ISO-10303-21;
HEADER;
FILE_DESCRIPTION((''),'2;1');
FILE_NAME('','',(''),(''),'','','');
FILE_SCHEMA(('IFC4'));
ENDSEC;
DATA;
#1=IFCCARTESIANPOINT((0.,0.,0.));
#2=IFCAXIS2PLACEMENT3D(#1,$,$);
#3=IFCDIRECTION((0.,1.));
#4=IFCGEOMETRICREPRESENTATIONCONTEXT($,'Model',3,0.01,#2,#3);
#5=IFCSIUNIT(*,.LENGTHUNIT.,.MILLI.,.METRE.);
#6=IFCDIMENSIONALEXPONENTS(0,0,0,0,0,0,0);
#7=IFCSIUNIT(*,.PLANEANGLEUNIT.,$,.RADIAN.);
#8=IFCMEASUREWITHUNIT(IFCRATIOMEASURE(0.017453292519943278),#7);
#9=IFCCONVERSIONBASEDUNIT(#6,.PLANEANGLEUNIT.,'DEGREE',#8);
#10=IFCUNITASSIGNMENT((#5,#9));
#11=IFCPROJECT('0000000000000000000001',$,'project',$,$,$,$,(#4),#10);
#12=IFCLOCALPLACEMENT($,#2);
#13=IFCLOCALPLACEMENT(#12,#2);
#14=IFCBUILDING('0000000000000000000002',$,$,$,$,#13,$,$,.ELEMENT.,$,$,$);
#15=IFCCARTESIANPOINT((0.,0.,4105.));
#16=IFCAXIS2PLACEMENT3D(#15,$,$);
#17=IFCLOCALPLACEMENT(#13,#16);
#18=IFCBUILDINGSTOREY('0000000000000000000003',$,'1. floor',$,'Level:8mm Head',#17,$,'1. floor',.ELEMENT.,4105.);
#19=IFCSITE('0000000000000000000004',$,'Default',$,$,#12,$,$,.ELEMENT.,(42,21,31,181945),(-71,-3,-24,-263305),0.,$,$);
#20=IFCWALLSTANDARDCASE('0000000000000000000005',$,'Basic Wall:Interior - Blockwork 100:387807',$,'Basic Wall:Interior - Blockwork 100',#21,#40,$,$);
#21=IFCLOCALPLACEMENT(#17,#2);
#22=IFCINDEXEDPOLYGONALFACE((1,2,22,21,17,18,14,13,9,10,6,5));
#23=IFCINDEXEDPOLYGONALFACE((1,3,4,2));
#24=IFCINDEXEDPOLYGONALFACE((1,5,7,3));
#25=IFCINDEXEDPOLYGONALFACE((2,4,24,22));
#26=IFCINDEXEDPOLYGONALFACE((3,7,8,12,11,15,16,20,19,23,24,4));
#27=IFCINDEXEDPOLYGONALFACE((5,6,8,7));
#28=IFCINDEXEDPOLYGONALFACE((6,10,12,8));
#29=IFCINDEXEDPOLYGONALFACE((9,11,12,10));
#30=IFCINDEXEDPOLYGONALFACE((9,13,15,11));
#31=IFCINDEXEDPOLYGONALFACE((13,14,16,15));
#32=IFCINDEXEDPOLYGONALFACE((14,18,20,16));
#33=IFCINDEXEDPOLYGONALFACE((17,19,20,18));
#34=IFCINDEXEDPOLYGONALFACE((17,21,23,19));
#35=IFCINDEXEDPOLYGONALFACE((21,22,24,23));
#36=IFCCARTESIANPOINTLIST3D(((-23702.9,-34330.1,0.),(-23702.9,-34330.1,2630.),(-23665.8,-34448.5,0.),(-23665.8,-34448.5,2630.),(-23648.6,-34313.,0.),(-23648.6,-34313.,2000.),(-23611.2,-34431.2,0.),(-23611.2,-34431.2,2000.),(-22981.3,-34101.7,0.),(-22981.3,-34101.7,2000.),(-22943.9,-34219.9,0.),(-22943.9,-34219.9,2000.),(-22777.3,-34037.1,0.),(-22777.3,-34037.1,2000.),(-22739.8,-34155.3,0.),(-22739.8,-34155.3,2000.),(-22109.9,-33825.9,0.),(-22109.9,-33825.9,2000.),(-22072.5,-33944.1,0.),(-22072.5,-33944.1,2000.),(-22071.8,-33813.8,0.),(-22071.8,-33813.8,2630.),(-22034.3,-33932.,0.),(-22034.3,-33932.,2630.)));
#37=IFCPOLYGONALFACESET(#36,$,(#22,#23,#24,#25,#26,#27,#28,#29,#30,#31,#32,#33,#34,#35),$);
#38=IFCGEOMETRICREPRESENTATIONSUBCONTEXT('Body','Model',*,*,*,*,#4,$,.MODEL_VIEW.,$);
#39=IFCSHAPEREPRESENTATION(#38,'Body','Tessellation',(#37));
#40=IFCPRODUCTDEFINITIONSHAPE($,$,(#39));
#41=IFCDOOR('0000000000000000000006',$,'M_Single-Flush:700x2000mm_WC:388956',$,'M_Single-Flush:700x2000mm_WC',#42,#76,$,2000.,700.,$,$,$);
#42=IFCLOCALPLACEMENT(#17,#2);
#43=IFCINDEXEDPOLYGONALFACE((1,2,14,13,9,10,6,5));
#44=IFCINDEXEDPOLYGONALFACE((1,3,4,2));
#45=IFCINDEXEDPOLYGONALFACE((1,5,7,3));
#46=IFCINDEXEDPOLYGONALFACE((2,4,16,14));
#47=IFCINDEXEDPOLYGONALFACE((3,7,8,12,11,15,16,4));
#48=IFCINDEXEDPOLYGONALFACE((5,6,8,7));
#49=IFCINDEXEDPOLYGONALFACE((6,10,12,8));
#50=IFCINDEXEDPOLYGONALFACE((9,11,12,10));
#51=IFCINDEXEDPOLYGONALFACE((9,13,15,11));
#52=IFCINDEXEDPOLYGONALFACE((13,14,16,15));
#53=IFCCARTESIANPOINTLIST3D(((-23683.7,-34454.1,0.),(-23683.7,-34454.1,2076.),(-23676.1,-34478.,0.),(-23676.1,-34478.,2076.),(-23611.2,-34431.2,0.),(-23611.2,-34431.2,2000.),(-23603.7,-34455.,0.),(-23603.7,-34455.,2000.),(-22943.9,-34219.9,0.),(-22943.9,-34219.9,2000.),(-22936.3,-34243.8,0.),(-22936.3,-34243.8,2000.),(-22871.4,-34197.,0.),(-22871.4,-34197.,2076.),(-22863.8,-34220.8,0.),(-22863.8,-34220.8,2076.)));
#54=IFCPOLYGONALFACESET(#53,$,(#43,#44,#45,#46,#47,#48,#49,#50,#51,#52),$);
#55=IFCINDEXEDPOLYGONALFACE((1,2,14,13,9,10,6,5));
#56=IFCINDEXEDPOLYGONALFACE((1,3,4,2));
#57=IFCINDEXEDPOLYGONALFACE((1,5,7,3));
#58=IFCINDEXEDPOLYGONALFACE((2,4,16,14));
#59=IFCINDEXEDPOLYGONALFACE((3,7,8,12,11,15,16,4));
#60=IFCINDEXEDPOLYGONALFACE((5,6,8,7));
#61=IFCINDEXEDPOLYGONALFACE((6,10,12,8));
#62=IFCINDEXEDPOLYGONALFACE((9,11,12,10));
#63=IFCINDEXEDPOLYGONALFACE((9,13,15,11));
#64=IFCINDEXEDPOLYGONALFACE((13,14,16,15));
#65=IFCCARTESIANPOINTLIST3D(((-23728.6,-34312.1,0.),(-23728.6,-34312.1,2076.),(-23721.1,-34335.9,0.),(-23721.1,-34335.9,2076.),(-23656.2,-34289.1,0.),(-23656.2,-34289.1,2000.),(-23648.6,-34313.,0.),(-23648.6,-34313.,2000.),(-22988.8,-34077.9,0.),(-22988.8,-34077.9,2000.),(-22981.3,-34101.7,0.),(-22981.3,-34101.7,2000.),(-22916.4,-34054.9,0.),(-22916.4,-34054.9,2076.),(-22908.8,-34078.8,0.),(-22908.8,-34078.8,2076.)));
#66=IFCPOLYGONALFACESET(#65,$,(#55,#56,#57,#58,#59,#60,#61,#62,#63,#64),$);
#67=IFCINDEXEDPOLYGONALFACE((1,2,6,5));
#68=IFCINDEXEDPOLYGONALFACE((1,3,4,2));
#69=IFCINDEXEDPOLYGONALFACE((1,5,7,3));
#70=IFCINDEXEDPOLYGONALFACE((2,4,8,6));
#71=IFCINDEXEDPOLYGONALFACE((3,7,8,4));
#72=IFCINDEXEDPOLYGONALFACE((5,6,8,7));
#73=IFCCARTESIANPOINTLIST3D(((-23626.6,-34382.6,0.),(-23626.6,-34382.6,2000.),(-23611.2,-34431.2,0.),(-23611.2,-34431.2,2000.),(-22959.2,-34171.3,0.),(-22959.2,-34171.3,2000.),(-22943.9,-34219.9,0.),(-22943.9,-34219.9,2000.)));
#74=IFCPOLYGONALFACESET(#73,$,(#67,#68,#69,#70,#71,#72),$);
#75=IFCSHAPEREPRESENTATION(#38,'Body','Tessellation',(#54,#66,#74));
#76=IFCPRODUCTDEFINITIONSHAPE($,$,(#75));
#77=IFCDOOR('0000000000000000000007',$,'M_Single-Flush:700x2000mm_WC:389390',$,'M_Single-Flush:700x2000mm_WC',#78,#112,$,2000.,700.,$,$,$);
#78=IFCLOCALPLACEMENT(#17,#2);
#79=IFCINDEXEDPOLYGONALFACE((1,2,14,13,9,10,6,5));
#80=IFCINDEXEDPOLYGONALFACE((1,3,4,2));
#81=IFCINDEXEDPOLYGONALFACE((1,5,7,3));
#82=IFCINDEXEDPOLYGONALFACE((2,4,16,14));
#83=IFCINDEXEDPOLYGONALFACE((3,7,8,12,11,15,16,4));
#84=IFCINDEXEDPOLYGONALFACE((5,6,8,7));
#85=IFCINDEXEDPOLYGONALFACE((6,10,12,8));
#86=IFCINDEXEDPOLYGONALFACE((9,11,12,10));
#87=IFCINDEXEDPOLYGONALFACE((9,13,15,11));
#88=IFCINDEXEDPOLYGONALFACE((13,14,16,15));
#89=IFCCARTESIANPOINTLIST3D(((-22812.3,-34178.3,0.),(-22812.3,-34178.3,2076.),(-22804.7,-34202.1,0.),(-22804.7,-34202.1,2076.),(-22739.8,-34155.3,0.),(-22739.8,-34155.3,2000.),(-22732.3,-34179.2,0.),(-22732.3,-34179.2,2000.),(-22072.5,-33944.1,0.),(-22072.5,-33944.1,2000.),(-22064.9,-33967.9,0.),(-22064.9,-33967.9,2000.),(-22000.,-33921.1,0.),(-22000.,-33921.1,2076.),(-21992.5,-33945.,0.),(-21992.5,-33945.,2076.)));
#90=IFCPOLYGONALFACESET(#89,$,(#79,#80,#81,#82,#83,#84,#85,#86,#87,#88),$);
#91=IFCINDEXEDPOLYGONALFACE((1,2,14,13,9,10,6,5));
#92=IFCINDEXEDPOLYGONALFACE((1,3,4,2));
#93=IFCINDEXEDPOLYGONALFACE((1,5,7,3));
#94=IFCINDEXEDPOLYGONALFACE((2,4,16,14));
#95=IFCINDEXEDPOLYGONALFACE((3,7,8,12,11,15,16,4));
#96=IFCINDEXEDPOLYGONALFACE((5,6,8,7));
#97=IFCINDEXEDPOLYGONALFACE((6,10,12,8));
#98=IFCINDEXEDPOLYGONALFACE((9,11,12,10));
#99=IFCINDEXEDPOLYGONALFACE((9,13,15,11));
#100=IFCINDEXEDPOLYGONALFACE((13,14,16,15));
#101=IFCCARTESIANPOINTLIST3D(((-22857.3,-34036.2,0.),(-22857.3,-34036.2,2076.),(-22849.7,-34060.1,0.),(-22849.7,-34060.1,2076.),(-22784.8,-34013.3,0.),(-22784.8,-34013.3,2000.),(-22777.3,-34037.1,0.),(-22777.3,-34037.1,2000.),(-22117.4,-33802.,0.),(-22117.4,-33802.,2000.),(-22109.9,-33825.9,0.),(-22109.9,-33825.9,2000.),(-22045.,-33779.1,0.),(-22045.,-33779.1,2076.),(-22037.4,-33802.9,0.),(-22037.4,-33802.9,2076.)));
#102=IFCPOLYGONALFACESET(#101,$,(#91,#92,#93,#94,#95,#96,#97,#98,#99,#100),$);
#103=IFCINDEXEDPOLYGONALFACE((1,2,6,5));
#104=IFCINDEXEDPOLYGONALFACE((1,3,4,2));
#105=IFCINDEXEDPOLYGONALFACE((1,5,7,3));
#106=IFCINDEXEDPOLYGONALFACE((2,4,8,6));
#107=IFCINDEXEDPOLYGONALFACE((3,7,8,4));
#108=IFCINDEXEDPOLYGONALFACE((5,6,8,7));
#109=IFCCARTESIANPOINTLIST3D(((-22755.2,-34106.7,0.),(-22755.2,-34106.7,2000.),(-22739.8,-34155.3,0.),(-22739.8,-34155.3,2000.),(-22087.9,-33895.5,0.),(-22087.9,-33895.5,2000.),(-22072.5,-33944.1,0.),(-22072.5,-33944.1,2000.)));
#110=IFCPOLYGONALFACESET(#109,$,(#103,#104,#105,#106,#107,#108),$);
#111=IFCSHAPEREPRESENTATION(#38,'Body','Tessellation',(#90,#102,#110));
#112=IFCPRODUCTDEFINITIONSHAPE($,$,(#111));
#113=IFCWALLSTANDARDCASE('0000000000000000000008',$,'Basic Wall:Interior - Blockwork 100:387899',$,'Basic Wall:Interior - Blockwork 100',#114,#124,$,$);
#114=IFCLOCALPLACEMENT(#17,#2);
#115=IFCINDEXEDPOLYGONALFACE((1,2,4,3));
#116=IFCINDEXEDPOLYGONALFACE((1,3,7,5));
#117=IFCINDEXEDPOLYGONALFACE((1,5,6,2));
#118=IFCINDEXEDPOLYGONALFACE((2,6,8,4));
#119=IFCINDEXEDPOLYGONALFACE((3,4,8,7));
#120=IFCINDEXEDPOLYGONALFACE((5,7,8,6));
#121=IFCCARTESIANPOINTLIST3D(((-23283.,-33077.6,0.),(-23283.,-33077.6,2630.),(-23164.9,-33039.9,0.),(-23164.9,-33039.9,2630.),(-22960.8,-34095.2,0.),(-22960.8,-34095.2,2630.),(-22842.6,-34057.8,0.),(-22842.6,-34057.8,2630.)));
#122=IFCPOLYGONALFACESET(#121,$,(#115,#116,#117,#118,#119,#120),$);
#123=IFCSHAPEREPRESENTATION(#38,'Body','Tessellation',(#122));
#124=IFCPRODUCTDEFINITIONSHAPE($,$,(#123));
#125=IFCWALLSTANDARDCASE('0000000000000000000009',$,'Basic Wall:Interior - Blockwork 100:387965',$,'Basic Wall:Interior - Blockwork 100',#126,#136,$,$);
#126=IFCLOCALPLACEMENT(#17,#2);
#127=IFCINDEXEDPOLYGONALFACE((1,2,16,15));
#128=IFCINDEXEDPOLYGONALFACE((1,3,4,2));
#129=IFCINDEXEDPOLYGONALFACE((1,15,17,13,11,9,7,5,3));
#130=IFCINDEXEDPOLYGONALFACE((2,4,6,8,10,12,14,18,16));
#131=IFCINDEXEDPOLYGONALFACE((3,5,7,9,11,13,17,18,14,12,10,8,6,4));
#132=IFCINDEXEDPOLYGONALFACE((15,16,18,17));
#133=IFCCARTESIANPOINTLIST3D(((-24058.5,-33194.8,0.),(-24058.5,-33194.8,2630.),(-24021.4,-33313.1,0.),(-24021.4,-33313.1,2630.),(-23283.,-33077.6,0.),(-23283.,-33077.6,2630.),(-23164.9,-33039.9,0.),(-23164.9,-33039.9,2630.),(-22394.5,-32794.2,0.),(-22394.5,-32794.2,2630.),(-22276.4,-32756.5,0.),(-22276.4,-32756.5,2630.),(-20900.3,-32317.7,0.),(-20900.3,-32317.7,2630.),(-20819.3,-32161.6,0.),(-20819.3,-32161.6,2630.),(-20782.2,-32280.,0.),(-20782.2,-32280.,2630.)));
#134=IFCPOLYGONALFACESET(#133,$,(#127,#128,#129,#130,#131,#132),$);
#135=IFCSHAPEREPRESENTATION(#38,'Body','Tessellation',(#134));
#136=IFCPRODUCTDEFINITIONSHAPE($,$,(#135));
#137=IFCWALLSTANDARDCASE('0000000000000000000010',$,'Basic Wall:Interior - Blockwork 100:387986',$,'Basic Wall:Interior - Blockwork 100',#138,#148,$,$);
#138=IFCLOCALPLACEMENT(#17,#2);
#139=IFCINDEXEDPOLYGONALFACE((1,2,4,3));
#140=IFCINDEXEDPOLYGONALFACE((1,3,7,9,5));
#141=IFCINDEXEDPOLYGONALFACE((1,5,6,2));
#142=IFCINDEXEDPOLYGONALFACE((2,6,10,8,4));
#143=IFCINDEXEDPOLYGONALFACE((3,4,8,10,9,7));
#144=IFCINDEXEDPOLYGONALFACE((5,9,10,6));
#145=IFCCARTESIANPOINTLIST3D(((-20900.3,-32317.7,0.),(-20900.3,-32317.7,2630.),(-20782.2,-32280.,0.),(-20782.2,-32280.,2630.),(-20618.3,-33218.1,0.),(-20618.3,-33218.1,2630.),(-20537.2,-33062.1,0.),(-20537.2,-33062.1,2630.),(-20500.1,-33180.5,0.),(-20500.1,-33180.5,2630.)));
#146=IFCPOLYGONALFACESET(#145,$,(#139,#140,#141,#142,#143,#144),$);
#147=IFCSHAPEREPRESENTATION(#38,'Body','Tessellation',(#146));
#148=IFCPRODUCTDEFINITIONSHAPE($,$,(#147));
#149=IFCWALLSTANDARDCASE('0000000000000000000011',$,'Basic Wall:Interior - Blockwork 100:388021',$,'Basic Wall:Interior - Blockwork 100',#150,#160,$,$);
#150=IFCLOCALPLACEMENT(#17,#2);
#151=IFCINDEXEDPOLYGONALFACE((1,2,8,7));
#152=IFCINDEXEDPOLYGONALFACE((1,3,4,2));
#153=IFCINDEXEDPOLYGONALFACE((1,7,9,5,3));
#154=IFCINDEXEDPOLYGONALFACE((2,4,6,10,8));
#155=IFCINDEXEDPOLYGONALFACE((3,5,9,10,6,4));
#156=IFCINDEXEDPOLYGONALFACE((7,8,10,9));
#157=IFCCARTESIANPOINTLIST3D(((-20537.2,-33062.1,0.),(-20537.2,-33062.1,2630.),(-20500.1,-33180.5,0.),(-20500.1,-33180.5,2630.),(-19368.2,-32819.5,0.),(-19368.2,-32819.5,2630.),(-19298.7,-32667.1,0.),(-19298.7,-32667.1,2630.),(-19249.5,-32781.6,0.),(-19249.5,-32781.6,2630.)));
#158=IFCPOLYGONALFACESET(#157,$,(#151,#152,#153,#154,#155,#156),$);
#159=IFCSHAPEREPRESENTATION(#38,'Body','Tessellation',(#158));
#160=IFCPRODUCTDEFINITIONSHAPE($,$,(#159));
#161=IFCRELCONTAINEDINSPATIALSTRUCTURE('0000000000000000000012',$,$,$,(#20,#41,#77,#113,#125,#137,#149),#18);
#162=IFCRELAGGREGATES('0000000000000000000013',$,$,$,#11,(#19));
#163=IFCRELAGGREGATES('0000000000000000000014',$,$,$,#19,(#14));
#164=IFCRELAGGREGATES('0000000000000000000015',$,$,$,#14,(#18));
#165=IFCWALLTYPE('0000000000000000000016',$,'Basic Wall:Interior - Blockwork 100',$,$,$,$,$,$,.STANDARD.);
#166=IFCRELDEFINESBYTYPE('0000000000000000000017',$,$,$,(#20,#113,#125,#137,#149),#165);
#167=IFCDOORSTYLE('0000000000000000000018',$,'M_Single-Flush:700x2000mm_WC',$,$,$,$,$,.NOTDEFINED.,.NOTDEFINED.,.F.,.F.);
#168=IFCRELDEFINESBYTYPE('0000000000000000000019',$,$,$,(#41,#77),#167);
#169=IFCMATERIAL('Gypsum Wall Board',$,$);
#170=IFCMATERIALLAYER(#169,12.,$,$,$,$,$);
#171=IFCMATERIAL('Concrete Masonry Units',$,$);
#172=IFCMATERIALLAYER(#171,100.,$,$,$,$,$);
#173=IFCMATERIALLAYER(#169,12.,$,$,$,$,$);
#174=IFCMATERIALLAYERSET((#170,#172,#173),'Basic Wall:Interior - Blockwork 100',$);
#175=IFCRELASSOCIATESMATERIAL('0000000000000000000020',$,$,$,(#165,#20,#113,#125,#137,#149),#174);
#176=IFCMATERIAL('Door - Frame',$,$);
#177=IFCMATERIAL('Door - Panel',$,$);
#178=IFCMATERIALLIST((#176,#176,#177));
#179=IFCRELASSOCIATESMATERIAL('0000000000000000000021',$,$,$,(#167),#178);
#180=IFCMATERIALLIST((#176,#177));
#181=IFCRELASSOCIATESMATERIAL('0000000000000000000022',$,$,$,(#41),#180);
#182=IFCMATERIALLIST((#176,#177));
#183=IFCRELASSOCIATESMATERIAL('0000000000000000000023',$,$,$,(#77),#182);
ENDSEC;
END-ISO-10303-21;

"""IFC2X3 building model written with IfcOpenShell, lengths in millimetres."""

from ifc_helpers import new_model, entity, si_unit, converted_unit, direction, frame, frame_2d, origin, origin_2d_with_axis, place, context, subcontext, project, spatial, polyline, rectangle, outline, extrude, source, transform, mapped, material, material_list, layer, layer_set, layer_usage, type_object, type_shapes, element, fill, save


model = new_model("IFC2X3")

# Units and contexts
model_context = context("Model", 3, precision=0.01, world=origin(), true_north=direction((0.0, 1.0)))
body_context = subcontext(model_context, "Body", "Model", "MODEL_VIEW")
ifc_project = project(units=[si_unit("LENGTHUNIT", "METRE", prefix="MILLI"), converted_unit("PLANEANGLEUNIT", "DEGREE", entity("IfcRatioMeasure", 0.017453292519943278), si_unit("PLANEANGLEUNIT", "RADIAN"), dimensions=[0, 0, 0, 0, 0, 0, 0])], contexts=[model_context])

# Site, building, storey
site_placement = place(None, origin())
site = spatial("IfcSite", under=ifc_project, at=site_placement, Name="Default", CompositionType="ELEMENT", RefLatitude=(42, 21, 31, 181945), RefLongitude=(-71, -3, -24, -263305), RefElevation=0.0)
building_placement = place(site_placement, origin())
building = spatial("IfcBuilding", under=site, at=building_placement, CompositionType="ELEMENT")
storey_placement = place(building_placement, frame((0.0, 0.0, 4105.0)))
storey = spatial("IfcBuildingStorey", under=building, at=storey_placement, Name="1. floor", ObjectType="Level:8mm Head", LongName="1. floor", CompositionType="ELEMENT", Elevation=4105.0)

# Shared definitions
ifc_material_1 = material(Name="Gypsum Wall Board")
ifc_layer_1 = layer(ifc_material_1, 12.0)
ifc_material_2 = material(Name="Concrete Masonry Units")
ifc_layer_2 = layer(ifc_material_2, 100.0)
ifc_layer_3 = layer(ifc_material_1, 12.0)
ifc_layer_set = layer_set([ifc_layer_1, ifc_layer_2, ifc_layer_3], Name="Basic Wall:Interior - Blockwork 100")
wall_type = type_object("IfcWallType", Name="Basic Wall:Interior - Blockwork 100", PredefinedType="STANDARD", material=ifc_layer_set)
ifc_material_3 = material(Name="Door - Frame")
ifc_material_4 = material(Name="Door - Panel")
ifc_material_list_1 = material_list([ifc_material_3, ifc_material_3, ifc_material_4])
door_style_1 = type_object("IfcDoorStyle", Name="M_Single-Flush:700x2000mm_WC", ConstructionType="NOTDEFINED", OperationType="NOTDEFINED", ParameterTakesPrecedence=False, Sizeable=False, material=ifc_material_list_1)
shared_shape_1 = source(origin(), body_context, "Body", "SweptSolid", [
    extrude(outline(polyline([(-426.0, -1057.0), (426.0, -1057.0), (426.0, 1019.0), (350.0, 1019.0), (350.0, -981.0), (-350.0, -981.0), (-350.0, 1019.0), (-426.0, 1019.0), (-426.0, -1057.0)])), frame((350.0, 124.0, 1019.0), z_axis=(0.0, 1.0, 0.0), x_axis=(1.0, 0.0, 0.0)), (0.0, 0.0, 1.0), 25.0),
    extrude(outline(polyline([(-1057.0, -426.0), (1019.0, -426.0), (1019.0, -350.0), (-981.0, -350.0), (-981.0, 350.0), (1019.0, 350.0), (1019.0, 426.0), (-1057.0, 426.0), (-1057.0, -426.0)])), frame((350.0, -25.0, 1019.0), z_axis=(0.0, 1.0, 0.0), x_axis=(0.0, 0.0, -1.0)), (0.0, 0.0, 1.0), 25.0),
    extrude(rectangle(XDim=51.0, YDim=700.0, at=origin_2d_with_axis()), frame((350.0, 98.5, 0.0), z_axis=(0.0, 0.0, 1.0), x_axis=(0.0, 1.0, 0.0)), (0.0, 0.0, 1.0), 2000.0),
])
type_shapes(door_style_1, [shared_shape_1])

# Wall, openings, doors
ifc_layer_usage_1 = layer_usage(ifc_layer_set, "AXIS2", "NEGATIVE", 62.0)
wall_1_placement = place(storey_placement, frame((-23684.5, -34389.4, 0.0), z_axis=(0.0, 0.0, 1.0), x_axis=(0.953372, 0.301797, 0.0)))
wall_1 = element("IfcWallStandardCase", 1, at=wall_1_placement, inside=storey, type_object=wall_type, material=ifc_layer_usage_1, Name="Basic Wall:Interior - Blockwork 100:387807", ObjectType="Basic Wall:Interior - Blockwork 100", context=body_context, shape_type="SweptSolid", body=[
    extrude(outline(polyline([(0.0, -62.0), (1711.2, -62.0), (1711.2, 62.0), (902.7, 62.0), (778.7, 62.0), (0.4, 62.0), (0.0, -62.0)])), origin(), (0.0, 0.0, 1.0), 2630.0),
])
opening_1_placement = place(wall_1_placement, frame((757.2, 62.0, 0.0)))
opening_1 = element("IfcOpeningElement", 2, at=opening_1_placement, cuts=wall_1, ObjectType="Opening", context=body_context, shape_type="SweptSolid", body=[
    extrude(rectangle(XDim=700.0, YDim=2000.0, at=frame_2d((1000.0, 350.0), x_axis=(0.0, 1.0))), frame((0.0, 0.0, 0.0), z_axis=(0.0, -1.0, 0.0), x_axis=(0.0, 0.0, 1.0)), (0.0, 0.0, 1.0), 124.0),
])
opening_2_placement = place(wall_1_placement, frame((1671.2, 62.0, 0.0)))
opening_2 = element("IfcOpeningElement", 3, at=opening_2_placement, cuts=wall_1, ObjectType="Opening", context=body_context, shape_type="SweptSolid", body=[
    extrude(rectangle(XDim=700.0, YDim=2000.0, at=frame_2d((1000.0, 350.0), x_axis=(0.0, 1.0))), frame((0.0, 0.0, 0.0), z_axis=(0.0, -1.0, 0.0), x_axis=(0.0, 0.0, 1.0)), (0.0, 0.0, 1.0), 124.0),
])
ifc_material_list_2 = material_list([ifc_material_3, ifc_material_4])
door_1_placement = place(opening_1_placement, frame((0.0, 0.0, 0.0), z_axis=(0.0, 0.0, 1.0), x_axis=(-1.0, 0.0, 0.0)))
door_1 = element("IfcDoor", 4, at=door_1_placement, inside=storey, type_object=door_style_1, material=ifc_material_list_2, Name="M_Single-Flush:700x2000mm_WC:388956", ObjectType="M_Single-Flush:700x2000mm_WC", OverallHeight=2000.0, OverallWidth=700.0, context=body_context, shape_type="MappedRepresentation", body=[
    mapped(shared_shape_1, transform((0.0, 0.0, 0.0), scale=1.0)),
])
fill(opening_1, door_1)
ifc_material_list_3 = material_list([ifc_material_3, ifc_material_4])
door_2_placement = place(opening_2_placement, frame((0.0, 0.0, 0.0), z_axis=(0.0, 0.0, 1.0), x_axis=(-1.0, 0.0, 0.0)))
door_2 = element("IfcDoor", 5, at=door_2_placement, inside=storey, type_object=door_style_1, material=ifc_material_list_3, Name="M_Single-Flush:700x2000mm_WC:389390", ObjectType="M_Single-Flush:700x2000mm_WC", OverallHeight=2000.0, OverallWidth=700.0, context=body_context, shape_type="MappedRepresentation", body=[
    mapped(shared_shape_1, transform((0.0, 0.0, 0.0), scale=1.0)),
])
fill(opening_2, door_2)

# Walls
ifc_layer_usage_2 = layer_usage(ifc_layer_set, "AXIS2", "NEGATIVE", 62.0)
wall_2_placement = place(storey_placement, frame((-23224.0, -33058.6, 0.0), z_axis=(0.0, 0.0, 1.0), x_axis=(0.301797, -0.953372, 0.0)))
element("IfcWallStandardCase", 6, at=wall_2_placement, inside=storey, type_object=wall_type, material=ifc_layer_usage_2, Name="Basic Wall:Interior - Blockwork 100:387899", ObjectType="Basic Wall:Interior - Blockwork 100", context=body_context, shape_type="SweptSolid", body=[
    extrude(outline(polyline([(1067.7, -62.0), (1067.7, 62.0), (0.0, 62.0), (0.3, -62.0), (1067.7, -62.0)])), origin(), (0.0, 0.0, 1.0), 2630.0),
])
ifc_layer_usage_3 = layer_usage(ifc_layer_set, "AXIS2", "NEGATIVE", 62.0)
wall_3_placement = place(storey_placement, frame((-24040.3, -33254.0, 0.0), z_axis=(0.0, 0.0, 1.0), x_axis=(0.952718, 0.303856, 0.0)))
element("IfcWallStandardCase", 7, at=wall_3_placement, inside=storey, type_object=wall_type, material=ifc_layer_usage_3, Name="Basic Wall:Interior - Blockwork 100:387965", ObjectType="Basic Wall:Interior - Blockwork 100", context=body_context, shape_type="SweptSolid", body=[
    extrude(outline(polyline([(3400.0, -62.0), (3400.6, 62.0), (0.6, 62.0), (0.0, -62.0), (775.1, -62.0), (899.1, -62.0), (1707.7, -62.0), (1831.7, -62.0), (3276.0, -62.0), (3400.0, -62.0)])), origin(), (0.0, 0.0, 1.0), 2630.0),
])
ifc_layer_usage_4 = layer_usage(ifc_layer_set, "AXIS2", "NEGATIVE", 62.0)
wall_4_placement = place(storey_placement, frame((-20841.4, -32298.5, 0.0), z_axis=(0.0, 0.0, 1.0), x_axis=(0.298924, -0.954277, 0.0)))
element("IfcWallStandardCase", 8, at=wall_4_placement, inside=storey, type_object=wall_type, material=ifc_layer_usage_4, Name="Basic Wall:Interior - Blockwork 100:387986", ObjectType="Basic Wall:Interior - Blockwork 100", context=body_context, shape_type="SweptSolid", body=[
    extrude(outline(polyline([(944.3, -62.0), (943.6, 62.0), (819.6, 62.0), (0.0, 62.0), (0.6, -62.0), (944.3, -62.0)])), origin(), (0.0, 0.0, 1.0), 2630.0),
])
ifc_layer_usage_5 = layer_usage(ifc_layer_set, "AXIS2", "NEGATIVE", 62.0)
wall_5_placement = place(storey_placement, frame((-20519.0, -33121.4, 0.0), z_axis=(0.0, 0.0, 1.0), x_axis=(0.952718, 0.303856, 0.0)))
element("IfcWallStandardCase", 9, at=wall_5_placement, inside=storey, type_object=wall_type, material=ifc_layer_usage_5, Name="Basic Wall:Interior - Blockwork 100:388021", ObjectType="Basic Wall:Interior - Blockwork 100", context=body_context, shape_type="SweptSolid", body=[
    extrude(outline(polyline([(1312.6, -62.0), (1300.6, 62.0), (0.6, 62.0), (0.0, -62.0), (1188.1, -62.0), (1312.6, -62.0)])), origin(), (0.0, 0.0, 1.0), 2630.0),
])

save(model, "model.ifc")
